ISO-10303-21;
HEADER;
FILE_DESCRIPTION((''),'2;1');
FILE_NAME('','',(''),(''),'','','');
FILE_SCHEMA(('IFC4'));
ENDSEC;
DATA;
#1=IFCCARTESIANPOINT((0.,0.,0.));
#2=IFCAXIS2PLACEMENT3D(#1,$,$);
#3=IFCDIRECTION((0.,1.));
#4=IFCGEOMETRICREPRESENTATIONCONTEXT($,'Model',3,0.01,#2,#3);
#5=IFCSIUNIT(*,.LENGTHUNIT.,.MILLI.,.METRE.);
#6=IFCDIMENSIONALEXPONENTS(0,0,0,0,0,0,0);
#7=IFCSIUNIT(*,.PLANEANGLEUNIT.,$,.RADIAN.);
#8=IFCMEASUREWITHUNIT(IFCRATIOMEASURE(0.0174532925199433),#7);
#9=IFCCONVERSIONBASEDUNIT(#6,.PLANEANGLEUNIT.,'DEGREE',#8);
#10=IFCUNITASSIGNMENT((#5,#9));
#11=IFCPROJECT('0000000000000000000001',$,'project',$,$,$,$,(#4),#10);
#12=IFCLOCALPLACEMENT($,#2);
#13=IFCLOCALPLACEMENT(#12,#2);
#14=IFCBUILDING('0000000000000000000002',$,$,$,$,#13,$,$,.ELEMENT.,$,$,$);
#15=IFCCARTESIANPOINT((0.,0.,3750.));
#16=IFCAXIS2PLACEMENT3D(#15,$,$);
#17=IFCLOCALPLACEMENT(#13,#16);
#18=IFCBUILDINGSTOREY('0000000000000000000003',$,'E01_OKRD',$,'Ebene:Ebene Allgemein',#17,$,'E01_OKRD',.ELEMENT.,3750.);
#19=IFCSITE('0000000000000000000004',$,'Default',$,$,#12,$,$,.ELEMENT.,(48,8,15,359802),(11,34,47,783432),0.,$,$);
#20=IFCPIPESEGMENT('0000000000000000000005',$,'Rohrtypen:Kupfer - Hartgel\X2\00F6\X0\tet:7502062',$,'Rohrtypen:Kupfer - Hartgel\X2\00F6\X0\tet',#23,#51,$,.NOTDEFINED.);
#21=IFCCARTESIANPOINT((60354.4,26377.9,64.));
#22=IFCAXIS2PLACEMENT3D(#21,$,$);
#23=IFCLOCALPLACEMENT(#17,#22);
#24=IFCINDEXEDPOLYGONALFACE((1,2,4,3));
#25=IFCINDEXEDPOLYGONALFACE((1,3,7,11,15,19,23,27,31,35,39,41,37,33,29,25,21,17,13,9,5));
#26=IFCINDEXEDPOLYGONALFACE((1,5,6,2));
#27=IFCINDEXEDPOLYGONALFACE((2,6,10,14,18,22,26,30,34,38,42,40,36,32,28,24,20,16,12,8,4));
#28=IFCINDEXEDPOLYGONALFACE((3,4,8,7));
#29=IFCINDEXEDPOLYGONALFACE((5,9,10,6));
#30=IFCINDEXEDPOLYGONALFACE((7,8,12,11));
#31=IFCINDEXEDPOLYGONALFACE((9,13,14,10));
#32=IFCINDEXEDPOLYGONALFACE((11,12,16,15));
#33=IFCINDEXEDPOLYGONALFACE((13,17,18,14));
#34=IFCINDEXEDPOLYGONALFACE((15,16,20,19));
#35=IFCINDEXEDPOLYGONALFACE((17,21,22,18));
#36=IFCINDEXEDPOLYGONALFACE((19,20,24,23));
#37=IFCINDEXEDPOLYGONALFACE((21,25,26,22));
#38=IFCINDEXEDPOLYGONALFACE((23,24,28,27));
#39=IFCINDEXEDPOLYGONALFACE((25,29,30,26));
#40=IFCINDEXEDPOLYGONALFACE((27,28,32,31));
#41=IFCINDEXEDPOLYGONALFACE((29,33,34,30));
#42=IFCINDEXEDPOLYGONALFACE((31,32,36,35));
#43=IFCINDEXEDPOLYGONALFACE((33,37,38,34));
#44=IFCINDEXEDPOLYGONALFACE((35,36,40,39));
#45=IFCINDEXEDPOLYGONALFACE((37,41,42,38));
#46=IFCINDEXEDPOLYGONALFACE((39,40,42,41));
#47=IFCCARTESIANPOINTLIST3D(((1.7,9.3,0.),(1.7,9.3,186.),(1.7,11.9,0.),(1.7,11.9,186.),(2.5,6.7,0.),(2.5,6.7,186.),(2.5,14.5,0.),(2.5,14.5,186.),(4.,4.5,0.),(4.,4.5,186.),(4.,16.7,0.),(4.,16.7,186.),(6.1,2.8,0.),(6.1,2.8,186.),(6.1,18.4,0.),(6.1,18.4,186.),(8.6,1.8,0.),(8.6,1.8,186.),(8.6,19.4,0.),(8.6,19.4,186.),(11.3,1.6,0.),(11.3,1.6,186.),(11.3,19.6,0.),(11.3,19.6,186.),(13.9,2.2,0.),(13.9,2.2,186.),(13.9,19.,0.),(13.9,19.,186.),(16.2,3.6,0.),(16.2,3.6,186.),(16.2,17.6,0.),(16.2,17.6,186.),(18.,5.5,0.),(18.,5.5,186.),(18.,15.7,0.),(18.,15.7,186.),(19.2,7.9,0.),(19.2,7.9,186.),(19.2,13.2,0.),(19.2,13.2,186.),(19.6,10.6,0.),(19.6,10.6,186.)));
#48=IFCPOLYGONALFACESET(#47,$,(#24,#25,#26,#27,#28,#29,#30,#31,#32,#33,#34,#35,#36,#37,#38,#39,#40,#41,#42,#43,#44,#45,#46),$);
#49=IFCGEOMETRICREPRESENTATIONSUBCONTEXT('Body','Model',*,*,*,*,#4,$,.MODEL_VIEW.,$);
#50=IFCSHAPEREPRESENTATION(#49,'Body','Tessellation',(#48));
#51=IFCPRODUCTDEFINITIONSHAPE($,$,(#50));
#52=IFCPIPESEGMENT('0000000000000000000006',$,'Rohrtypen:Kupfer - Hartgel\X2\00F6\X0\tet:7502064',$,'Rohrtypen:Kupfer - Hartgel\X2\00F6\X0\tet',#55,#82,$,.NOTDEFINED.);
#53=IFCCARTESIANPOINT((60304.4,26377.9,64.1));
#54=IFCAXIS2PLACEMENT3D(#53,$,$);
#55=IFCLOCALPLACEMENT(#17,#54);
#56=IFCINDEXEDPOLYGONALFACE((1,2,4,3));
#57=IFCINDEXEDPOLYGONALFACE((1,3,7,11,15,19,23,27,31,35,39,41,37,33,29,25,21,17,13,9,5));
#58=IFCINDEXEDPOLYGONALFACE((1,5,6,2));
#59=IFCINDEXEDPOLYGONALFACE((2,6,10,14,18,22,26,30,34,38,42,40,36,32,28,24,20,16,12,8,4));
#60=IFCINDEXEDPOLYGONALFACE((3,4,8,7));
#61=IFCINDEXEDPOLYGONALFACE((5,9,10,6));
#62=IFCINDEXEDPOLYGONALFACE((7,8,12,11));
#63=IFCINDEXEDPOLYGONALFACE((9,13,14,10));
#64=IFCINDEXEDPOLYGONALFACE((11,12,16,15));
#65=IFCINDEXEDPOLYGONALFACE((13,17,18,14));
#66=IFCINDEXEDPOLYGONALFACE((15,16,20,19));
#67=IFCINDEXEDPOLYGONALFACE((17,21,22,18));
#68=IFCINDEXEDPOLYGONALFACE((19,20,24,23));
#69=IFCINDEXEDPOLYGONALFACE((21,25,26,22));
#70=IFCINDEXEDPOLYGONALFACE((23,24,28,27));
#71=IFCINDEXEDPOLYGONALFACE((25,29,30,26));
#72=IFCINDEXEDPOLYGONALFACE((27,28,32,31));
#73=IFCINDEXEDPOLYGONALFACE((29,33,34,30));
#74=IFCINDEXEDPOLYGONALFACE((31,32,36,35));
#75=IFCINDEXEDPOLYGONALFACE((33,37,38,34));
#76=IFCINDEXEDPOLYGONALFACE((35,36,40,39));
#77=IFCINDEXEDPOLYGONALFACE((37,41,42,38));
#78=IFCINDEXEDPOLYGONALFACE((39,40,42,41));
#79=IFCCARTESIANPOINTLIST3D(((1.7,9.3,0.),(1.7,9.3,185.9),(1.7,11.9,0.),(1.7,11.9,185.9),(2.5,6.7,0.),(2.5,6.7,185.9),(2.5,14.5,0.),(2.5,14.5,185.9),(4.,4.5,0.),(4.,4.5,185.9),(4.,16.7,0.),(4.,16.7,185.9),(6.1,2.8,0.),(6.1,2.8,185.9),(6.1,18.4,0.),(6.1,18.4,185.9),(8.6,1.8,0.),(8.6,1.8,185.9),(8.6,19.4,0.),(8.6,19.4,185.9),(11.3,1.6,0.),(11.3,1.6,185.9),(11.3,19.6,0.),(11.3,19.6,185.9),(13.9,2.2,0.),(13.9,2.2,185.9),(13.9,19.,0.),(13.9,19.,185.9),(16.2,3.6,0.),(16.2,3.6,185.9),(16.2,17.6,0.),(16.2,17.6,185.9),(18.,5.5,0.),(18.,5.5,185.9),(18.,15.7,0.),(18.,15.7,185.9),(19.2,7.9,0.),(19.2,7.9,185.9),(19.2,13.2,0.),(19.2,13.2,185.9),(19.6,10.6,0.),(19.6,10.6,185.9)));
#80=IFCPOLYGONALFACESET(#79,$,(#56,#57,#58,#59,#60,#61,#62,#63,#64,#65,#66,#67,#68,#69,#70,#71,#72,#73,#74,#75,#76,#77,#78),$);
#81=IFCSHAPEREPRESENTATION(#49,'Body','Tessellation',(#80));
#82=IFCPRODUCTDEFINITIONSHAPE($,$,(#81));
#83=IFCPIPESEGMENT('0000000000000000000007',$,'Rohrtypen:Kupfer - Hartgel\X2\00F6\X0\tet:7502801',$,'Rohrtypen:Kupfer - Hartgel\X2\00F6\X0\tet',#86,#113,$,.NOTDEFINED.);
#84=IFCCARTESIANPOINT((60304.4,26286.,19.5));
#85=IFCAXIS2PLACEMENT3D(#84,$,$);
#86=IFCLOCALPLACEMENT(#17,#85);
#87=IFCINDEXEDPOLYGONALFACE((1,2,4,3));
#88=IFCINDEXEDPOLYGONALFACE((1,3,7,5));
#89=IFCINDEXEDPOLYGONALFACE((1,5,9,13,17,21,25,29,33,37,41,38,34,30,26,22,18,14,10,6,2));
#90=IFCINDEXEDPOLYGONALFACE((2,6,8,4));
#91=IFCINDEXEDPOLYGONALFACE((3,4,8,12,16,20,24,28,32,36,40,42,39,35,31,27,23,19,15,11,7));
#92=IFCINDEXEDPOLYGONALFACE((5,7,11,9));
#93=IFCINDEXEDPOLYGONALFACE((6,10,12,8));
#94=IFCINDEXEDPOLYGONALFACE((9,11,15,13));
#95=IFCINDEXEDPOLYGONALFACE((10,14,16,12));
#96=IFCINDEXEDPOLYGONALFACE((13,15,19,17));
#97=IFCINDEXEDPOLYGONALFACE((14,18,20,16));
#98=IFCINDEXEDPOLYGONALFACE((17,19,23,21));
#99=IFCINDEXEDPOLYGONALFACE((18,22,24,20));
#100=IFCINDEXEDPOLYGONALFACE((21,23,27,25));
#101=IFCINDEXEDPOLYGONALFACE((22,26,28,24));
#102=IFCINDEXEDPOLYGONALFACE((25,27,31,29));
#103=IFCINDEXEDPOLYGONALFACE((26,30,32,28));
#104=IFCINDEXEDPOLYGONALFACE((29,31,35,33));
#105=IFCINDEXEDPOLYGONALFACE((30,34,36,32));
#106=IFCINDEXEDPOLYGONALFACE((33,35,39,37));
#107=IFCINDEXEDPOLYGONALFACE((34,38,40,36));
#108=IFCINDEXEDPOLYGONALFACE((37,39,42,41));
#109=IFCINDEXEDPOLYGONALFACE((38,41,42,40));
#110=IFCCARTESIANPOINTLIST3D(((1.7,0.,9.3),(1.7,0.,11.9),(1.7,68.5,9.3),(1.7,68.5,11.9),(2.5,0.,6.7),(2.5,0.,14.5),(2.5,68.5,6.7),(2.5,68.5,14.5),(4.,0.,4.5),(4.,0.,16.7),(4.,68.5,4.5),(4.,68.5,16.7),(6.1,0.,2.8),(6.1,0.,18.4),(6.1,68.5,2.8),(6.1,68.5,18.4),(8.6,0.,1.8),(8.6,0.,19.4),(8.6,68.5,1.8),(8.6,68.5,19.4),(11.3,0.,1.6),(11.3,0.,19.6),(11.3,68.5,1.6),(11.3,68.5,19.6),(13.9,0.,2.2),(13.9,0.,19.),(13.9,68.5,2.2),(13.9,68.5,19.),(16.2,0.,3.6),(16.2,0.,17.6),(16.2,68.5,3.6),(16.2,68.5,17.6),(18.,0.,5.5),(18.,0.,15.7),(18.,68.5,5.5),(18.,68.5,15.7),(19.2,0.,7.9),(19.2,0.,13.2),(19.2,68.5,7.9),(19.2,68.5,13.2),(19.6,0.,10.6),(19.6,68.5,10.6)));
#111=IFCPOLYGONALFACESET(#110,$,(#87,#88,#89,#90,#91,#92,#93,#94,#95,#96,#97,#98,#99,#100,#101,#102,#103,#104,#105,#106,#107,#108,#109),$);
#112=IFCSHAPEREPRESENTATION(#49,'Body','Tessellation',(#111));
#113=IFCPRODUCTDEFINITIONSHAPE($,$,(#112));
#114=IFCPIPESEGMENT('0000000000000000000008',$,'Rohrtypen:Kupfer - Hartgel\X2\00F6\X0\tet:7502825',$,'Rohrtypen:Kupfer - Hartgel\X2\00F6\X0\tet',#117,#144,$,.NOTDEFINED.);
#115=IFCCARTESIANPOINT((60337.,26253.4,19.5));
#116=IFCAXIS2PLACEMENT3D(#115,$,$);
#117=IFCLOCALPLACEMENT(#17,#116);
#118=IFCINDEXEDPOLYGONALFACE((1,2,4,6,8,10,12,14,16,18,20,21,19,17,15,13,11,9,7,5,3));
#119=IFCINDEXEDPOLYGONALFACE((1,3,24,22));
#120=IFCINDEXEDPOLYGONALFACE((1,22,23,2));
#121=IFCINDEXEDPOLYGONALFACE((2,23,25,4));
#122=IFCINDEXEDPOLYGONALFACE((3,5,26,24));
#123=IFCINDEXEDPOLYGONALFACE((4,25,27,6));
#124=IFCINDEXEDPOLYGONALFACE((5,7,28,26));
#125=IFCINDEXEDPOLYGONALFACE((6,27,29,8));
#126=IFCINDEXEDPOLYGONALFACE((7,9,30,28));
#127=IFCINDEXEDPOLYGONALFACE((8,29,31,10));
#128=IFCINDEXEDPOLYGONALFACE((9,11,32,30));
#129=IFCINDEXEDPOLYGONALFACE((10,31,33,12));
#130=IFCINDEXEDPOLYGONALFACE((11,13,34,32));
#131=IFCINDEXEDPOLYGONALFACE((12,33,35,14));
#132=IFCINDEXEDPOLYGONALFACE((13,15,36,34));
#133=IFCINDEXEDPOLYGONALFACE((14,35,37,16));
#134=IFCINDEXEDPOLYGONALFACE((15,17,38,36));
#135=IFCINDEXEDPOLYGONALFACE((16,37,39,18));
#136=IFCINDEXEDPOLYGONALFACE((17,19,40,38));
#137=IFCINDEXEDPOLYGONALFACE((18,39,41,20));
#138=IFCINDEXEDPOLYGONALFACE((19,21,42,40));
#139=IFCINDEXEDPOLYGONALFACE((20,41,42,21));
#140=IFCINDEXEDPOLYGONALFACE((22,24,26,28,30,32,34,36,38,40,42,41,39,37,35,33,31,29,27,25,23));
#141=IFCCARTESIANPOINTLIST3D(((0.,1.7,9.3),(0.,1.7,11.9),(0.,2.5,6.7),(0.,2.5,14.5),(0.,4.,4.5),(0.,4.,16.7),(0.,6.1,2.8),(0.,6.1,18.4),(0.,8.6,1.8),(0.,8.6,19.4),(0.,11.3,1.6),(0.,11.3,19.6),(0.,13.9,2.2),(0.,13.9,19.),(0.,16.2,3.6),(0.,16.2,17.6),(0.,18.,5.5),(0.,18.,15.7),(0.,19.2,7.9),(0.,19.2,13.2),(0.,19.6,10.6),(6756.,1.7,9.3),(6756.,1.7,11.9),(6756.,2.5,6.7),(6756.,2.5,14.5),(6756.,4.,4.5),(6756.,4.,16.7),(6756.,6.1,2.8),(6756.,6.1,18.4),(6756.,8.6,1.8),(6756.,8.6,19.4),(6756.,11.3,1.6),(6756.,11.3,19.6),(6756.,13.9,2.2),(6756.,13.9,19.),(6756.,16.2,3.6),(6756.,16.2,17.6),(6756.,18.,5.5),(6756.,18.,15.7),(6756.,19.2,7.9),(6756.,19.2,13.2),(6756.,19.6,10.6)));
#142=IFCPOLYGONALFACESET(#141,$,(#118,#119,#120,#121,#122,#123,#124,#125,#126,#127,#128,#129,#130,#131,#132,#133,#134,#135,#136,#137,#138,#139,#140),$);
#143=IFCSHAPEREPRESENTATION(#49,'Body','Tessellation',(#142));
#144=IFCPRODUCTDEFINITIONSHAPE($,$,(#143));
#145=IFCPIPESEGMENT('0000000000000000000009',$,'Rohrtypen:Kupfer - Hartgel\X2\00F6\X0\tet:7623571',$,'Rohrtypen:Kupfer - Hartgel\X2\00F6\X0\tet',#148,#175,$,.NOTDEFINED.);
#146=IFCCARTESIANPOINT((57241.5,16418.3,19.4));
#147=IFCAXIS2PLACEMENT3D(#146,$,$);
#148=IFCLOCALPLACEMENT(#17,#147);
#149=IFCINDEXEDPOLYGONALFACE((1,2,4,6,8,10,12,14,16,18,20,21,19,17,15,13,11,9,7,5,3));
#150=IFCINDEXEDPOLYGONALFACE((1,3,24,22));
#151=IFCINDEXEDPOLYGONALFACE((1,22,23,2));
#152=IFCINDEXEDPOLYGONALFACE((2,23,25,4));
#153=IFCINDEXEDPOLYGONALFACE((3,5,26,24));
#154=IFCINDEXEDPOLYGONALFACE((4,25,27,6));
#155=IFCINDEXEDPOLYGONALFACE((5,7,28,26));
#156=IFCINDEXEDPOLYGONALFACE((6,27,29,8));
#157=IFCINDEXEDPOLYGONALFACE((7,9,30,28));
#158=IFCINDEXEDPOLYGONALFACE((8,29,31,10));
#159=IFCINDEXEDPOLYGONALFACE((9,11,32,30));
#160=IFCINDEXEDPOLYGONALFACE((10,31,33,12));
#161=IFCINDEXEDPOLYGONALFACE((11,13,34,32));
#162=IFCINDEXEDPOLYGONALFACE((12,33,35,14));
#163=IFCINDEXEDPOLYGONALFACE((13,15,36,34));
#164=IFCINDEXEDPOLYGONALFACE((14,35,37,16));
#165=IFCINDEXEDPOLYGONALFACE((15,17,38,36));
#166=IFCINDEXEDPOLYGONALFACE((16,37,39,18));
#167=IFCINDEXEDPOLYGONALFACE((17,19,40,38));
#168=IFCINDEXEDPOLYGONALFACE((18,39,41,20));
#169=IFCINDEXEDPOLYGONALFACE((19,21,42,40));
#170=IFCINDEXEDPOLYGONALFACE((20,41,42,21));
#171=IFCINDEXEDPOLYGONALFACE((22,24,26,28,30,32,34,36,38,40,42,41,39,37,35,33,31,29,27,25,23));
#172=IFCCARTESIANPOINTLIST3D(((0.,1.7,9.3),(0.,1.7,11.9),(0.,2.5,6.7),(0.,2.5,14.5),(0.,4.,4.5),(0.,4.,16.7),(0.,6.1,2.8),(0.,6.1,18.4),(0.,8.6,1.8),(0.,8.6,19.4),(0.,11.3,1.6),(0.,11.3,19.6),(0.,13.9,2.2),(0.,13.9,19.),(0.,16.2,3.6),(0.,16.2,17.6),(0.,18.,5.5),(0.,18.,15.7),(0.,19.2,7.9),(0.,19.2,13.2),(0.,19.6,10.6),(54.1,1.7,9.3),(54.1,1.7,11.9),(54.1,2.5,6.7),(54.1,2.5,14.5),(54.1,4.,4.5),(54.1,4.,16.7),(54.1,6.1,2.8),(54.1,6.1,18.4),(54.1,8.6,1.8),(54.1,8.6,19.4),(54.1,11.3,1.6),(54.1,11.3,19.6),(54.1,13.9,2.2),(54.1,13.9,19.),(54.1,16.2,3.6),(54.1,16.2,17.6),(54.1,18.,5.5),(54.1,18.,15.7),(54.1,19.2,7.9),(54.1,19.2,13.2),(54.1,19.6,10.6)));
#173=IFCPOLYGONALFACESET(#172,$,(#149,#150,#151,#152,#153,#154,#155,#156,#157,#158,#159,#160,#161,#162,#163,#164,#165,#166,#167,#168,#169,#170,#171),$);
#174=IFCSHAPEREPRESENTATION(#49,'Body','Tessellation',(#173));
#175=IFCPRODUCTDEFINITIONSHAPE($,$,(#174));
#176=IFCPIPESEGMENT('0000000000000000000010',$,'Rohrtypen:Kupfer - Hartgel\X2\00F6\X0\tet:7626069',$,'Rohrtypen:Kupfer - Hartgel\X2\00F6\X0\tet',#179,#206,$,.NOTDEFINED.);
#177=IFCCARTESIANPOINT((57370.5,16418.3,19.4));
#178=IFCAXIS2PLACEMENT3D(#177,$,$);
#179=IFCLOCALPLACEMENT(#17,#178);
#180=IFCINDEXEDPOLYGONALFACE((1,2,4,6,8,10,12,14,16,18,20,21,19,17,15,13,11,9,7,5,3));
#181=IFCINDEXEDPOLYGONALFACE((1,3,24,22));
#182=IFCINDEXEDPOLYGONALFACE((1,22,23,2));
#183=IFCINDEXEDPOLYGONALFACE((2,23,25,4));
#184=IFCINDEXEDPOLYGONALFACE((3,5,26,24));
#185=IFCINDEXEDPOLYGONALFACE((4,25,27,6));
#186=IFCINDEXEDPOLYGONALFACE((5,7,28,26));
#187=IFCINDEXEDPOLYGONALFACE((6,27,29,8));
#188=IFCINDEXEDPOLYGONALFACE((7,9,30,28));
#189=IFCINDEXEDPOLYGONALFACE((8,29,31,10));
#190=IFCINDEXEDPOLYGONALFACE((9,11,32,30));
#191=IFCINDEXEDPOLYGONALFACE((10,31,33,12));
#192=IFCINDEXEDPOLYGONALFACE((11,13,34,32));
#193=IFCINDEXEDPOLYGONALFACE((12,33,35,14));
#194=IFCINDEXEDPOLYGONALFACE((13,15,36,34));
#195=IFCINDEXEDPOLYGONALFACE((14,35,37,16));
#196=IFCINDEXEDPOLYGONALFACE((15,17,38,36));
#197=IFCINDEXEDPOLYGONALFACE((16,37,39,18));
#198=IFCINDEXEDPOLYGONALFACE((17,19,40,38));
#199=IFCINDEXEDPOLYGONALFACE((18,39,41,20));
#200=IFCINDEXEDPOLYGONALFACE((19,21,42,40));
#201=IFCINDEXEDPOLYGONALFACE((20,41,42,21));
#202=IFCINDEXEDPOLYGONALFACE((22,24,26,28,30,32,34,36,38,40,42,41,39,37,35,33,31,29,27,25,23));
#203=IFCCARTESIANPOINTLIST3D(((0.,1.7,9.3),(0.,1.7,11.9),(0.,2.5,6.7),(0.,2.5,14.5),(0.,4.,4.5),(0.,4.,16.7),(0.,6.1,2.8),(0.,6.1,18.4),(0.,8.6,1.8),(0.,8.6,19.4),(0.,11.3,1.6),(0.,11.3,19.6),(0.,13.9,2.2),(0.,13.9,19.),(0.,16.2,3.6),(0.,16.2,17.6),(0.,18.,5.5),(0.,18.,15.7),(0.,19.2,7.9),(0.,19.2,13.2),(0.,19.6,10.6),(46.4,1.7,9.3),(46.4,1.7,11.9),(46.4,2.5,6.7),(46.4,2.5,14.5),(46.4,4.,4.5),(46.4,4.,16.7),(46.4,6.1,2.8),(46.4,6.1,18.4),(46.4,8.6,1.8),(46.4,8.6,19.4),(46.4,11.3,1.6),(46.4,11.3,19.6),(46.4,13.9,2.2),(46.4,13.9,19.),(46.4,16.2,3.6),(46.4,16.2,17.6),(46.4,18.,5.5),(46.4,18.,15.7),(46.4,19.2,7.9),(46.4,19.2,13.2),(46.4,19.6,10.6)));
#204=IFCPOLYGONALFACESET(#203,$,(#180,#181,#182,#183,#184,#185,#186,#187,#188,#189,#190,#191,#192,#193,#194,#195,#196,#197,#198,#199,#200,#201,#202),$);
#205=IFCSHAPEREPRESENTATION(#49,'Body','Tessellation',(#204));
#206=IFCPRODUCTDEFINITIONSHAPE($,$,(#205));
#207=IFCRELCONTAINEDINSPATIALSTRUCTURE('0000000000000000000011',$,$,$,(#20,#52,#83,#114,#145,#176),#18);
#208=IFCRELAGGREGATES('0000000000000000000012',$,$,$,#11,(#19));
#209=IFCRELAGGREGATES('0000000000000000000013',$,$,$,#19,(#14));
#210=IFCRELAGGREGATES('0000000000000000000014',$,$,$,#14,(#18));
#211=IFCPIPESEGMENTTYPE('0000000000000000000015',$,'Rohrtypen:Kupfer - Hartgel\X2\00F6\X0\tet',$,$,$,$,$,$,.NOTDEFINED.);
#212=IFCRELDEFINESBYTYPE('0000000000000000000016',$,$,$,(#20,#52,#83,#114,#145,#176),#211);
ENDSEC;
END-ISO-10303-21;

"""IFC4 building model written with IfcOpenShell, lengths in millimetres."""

from ifc_helpers import new_model, entity, si_unit, converted_unit, direction, frame, frame_2d, origin, origin_2d_with_axis, place, context, subcontext, project, spatial, circle, extrude, type_object, element, save


model = new_model("IFC4")

# Units and contexts
model_context = context("Model", 3, precision=0.01, world=origin(), true_north=direction((0.0, 1.0)))
body_context = subcontext(model_context, "Body", "Model", "MODEL_VIEW")
ifc_project = project(units=[si_unit("LENGTHUNIT", "METRE", prefix="MILLI"), converted_unit("PLANEANGLEUNIT", "DEGREE", entity("IfcRatioMeasure", 0.0174532925199433), si_unit("PLANEANGLEUNIT", "RADIAN"), dimensions=[0, 0, 0, 0, 0, 0, 0])], contexts=[model_context])

# Site, building, storey
site_placement = place(None, origin())
site = spatial("IfcSite", under=ifc_project, at=site_placement, Name="Default", CompositionType="ELEMENT", RefLatitude=(48, 8, 15, 359802), RefLongitude=(11, 34, 47, 783432), RefElevation=0.0)
building_placement = place(site_placement, origin())
building = spatial("IfcBuilding", under=site, at=building_placement, CompositionType="ELEMENT")
storey_placement = place(building_placement, frame((0.0, 0.0, 3750.0)))
storey = spatial("IfcBuildingStorey", under=building, at=storey_placement, Name="E01_OKRD", ObjectType="Ebene:Ebene Allgemein", LongName="E01_OKRD", CompositionType="ELEMENT", Elevation=3750.0)

# Pipe segments
pipe_segment_type = type_object("IfcPipeSegmentType", Name="Rohrtypen:Kupfer - Hartgelötet", PredefinedType="NOTDEFINED")
pipe_segment_1_placement = place(storey_placement, frame((60354.4, 26377.9, 64.0)))
element("IfcPipeSegment", 1, at=pipe_segment_1_placement, inside=storey, type_object=pipe_segment_type, Name="Rohrtypen:Kupfer - Hartgelötet:7502062", ObjectType="Rohrtypen:Kupfer - Hartgelötet", PredefinedType="NOTDEFINED", context=body_context, shape_type="SweptSolid", body=[
    extrude(circle(Radius=9.0, at=origin_2d_with_axis()), frame((10.6, 10.6, 0.0)), (0.0, 0.0, 1.0), 186.0),
])
pipe_segment_2_placement = place(storey_placement, frame((60304.4, 26377.9, 64.1)))
element("IfcPipeSegment", 2, at=pipe_segment_2_placement, inside=storey, type_object=pipe_segment_type, Name="Rohrtypen:Kupfer - Hartgelötet:7502064", ObjectType="Rohrtypen:Kupfer - Hartgelötet", PredefinedType="NOTDEFINED", context=body_context, shape_type="SweptSolid", body=[
    extrude(circle(Radius=9.0, at=origin_2d_with_axis()), frame((10.6, 10.6, 0.0)), (0.0, 0.0, 1.0), 185.9),
])
pipe_segment_3_placement = place(storey_placement, frame((60304.4, 26286.0, 19.5)))
element("IfcPipeSegment", 3, at=pipe_segment_3_placement, inside=storey, type_object=pipe_segment_type, Name="Rohrtypen:Kupfer - Hartgelötet:7502801", ObjectType="Rohrtypen:Kupfer - Hartgelötet", PredefinedType="NOTDEFINED", context=body_context, shape_type="SweptSolid", body=[
    extrude(circle(Radius=9.0, at=origin_2d_with_axis()), frame((10.6, 0.0, 10.6), z_axis=(0.0, 1.0, 0.0), x_axis=(1.0, 0.0, 0.0)), (0.0, 0.0, 1.0), 68.5),
])
pipe_segment_4_placement = place(storey_placement, frame((60337.0, 26253.4, 19.5)))
element("IfcPipeSegment", 4, at=pipe_segment_4_placement, inside=storey, type_object=pipe_segment_type, Name="Rohrtypen:Kupfer - Hartgelötet:7502825", ObjectType="Rohrtypen:Kupfer - Hartgelötet", PredefinedType="NOTDEFINED", context=body_context, shape_type="SweptSolid", body=[
    extrude(circle(Radius=9.0, at=origin_2d_with_axis()), frame((0.0, 10.6, 10.6), z_axis=(1.0, 0.0, 0.0), x_axis=(0.0, 1.0, 0.0)), (0.0, 0.0, 1.0), 6756.0),
])
pipe_segment_5_placement = place(storey_placement, frame((57241.5, 16418.3, 19.4)))
element("IfcPipeSegment", 5, at=pipe_segment_5_placement, inside=storey, type_object=pipe_segment_type, Name="Rohrtypen:Kupfer - Hartgelötet:7623571", ObjectType="Rohrtypen:Kupfer - Hartgelötet", PredefinedType="NOTDEFINED", context=body_context, shape_type="SweptSolid", body=[
    extrude(circle(Radius=9.0, at=frame_2d((0.0, 0.0), x_axis=(1.0, 0.0))), frame((0.0, 10.6, 10.6), z_axis=(1.0, 0.0, 0.0), x_axis=(0.0, 1.0, 0.0)), (0.0, 0.0, 1.0), 54.1),
])
pipe_segment_6_placement = place(storey_placement, frame((57370.5, 16418.3, 19.4)))
element("IfcPipeSegment", 6, at=pipe_segment_6_placement, inside=storey, type_object=pipe_segment_type, Name="Rohrtypen:Kupfer - Hartgelötet:7626069", ObjectType="Rohrtypen:Kupfer - Hartgelötet", PredefinedType="NOTDEFINED", context=body_context, shape_type="SweptSolid", body=[
    extrude(circle(Radius=9.0, at=frame_2d((0.0, 0.0), x_axis=(1.0, 0.0))), frame((0.0, 10.6, 10.6), z_axis=(1.0, 0.0, 0.0), x_axis=(0.0, 1.0, 0.0)), (0.0, 0.0, 1.0), 46.4),
])

save(model, "model.ifc")
